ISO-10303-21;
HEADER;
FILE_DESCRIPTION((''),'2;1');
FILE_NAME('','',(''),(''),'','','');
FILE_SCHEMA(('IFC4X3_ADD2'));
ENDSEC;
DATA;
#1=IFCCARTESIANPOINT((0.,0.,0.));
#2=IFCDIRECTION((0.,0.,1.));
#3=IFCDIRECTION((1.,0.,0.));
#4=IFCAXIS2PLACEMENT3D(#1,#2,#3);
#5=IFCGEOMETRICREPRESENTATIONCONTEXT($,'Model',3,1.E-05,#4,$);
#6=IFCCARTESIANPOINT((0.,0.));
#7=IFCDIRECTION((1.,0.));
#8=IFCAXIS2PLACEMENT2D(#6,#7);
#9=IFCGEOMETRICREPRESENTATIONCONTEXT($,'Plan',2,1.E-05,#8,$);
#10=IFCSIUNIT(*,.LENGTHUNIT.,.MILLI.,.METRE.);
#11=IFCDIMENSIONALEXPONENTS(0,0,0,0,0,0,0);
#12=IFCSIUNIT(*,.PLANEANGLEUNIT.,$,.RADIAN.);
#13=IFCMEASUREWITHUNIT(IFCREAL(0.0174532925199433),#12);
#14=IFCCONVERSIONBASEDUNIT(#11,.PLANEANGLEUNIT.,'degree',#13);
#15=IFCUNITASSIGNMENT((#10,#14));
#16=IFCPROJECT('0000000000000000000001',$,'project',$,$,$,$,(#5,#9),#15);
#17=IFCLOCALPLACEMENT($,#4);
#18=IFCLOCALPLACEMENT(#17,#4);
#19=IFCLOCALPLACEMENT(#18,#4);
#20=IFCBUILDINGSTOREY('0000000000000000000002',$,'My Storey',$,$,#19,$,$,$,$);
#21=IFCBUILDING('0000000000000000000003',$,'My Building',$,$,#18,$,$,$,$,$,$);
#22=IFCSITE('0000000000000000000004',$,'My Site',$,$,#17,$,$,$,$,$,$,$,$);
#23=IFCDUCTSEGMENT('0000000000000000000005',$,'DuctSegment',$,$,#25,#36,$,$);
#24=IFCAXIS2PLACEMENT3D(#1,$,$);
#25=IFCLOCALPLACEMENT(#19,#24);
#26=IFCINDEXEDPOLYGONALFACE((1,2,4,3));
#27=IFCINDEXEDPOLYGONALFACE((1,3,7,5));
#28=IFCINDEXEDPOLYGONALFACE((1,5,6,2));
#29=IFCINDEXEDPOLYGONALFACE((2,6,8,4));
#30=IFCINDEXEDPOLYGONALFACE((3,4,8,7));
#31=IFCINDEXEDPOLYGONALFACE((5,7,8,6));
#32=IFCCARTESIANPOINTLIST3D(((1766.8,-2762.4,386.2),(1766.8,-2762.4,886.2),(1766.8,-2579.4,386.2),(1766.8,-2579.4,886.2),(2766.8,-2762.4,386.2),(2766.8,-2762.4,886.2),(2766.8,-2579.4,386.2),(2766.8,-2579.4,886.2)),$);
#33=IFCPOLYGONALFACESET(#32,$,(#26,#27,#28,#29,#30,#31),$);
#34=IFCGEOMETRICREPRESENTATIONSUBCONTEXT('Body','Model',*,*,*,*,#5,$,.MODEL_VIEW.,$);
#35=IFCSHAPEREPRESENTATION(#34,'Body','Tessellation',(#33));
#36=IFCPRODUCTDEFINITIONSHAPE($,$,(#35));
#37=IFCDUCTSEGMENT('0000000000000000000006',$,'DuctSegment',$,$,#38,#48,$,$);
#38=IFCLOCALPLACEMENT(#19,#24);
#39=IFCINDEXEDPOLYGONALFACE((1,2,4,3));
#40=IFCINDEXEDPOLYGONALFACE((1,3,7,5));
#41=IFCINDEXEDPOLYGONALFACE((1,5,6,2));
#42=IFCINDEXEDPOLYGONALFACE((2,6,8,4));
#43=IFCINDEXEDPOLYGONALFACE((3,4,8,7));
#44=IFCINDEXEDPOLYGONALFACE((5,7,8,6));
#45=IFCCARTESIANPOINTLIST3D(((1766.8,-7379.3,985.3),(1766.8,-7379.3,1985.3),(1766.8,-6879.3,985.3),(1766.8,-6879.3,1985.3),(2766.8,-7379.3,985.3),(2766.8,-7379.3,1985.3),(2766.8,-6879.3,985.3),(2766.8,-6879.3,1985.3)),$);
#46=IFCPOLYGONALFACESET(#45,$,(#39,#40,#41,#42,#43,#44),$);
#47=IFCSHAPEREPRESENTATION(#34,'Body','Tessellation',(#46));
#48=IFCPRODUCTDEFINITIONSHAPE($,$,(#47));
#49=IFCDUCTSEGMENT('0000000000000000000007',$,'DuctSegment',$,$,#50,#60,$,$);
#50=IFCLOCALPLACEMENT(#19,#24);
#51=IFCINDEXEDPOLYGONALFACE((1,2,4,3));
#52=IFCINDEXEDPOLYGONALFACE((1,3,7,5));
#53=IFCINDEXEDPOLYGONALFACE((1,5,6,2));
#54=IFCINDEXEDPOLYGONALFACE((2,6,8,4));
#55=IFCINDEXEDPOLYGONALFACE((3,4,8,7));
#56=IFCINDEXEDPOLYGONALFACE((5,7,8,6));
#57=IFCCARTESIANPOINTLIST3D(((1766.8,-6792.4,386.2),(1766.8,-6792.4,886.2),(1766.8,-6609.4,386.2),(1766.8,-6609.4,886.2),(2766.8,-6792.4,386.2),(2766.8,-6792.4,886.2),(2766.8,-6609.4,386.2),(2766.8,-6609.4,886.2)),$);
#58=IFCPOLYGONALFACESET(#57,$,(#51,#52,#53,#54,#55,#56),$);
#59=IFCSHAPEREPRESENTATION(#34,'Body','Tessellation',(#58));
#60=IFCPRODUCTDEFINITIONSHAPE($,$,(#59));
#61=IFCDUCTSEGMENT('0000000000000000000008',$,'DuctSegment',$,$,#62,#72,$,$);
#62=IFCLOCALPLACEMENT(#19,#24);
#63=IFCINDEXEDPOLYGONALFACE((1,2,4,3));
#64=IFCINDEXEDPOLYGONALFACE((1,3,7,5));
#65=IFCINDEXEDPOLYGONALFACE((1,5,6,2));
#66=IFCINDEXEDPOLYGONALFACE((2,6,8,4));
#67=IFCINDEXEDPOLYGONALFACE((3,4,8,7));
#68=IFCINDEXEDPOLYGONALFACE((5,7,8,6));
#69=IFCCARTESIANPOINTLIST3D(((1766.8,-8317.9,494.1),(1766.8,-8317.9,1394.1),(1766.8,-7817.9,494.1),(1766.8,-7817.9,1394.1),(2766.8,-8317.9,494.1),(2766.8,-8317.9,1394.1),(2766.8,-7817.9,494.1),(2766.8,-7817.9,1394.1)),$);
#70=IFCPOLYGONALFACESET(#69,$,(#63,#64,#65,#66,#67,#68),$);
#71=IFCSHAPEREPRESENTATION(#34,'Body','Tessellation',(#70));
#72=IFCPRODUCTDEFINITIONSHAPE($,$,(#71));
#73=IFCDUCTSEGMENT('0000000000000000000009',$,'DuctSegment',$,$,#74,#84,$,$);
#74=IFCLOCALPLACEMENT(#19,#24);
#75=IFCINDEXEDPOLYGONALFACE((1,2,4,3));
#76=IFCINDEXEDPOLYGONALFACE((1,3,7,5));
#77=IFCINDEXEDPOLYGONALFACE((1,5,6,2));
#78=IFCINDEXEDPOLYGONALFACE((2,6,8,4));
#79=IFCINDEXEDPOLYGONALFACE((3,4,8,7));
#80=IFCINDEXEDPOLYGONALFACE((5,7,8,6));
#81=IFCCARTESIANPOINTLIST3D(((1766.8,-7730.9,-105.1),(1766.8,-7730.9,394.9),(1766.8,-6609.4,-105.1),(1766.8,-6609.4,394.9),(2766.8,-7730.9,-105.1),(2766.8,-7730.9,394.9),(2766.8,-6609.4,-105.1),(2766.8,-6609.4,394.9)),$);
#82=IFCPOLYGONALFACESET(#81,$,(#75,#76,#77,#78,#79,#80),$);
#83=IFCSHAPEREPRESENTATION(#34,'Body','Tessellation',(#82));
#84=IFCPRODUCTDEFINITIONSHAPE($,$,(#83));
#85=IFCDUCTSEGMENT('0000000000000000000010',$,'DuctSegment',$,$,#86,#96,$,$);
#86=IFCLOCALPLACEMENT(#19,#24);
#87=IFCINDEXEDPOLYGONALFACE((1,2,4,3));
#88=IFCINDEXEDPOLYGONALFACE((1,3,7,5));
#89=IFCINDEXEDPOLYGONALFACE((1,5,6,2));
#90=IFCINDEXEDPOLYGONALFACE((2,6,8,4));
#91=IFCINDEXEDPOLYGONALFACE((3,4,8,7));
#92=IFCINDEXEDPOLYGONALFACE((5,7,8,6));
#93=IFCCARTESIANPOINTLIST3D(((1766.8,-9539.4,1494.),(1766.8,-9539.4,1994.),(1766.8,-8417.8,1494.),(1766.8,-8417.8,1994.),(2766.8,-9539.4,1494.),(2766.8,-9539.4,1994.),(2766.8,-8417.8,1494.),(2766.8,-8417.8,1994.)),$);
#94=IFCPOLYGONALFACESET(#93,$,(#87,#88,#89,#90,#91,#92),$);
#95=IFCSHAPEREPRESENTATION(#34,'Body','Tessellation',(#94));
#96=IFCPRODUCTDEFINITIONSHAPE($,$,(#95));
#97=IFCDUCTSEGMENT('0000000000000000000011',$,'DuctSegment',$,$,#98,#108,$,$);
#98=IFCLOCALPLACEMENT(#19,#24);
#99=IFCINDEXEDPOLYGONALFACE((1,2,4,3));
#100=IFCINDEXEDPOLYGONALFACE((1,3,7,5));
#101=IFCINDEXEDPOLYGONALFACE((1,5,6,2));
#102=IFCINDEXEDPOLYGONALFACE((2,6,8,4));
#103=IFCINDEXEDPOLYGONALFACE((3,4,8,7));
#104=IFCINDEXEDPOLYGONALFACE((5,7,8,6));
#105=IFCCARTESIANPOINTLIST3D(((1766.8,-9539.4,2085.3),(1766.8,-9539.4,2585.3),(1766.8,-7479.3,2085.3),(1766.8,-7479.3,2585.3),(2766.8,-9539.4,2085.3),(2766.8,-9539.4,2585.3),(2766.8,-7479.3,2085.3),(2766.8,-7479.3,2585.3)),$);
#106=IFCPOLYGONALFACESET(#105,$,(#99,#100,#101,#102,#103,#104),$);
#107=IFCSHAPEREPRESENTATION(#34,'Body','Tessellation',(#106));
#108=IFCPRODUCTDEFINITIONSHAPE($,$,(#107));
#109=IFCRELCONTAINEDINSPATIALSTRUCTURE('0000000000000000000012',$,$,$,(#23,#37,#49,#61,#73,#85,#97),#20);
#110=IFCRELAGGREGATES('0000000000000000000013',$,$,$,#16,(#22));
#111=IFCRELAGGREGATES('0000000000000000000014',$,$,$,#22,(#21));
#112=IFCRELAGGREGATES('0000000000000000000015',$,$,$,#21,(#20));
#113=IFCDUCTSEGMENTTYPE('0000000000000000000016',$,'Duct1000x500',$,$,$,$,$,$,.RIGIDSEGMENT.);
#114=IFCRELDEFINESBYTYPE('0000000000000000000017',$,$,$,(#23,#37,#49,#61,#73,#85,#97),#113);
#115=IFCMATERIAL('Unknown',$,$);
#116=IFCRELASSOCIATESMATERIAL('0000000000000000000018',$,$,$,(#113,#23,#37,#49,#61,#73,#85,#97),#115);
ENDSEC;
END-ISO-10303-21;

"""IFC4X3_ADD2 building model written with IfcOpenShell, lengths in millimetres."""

from ifc_helpers import new_model, entity, si_unit, converted_unit, frame, origin_with_axes, origin_2d_with_axis, place, context, subcontext, project, spatial, rectangle, extrude, material, material_profile, profile_set, profile_usage, type_object, element, save


model = new_model("IFC4X3_ADD2")

# Units and contexts
model_context = context("Model", 3, precision=1e-05, world=origin_with_axes())
plan_context = context("Plan", 2, precision=1e-05, world=origin_2d_with_axis())
body_context = subcontext(model_context, "Body", "Model", "MODEL_VIEW")
ifc_project = project(units=[si_unit("LENGTHUNIT", "METRE", prefix="MILLI"), converted_unit("PLANEANGLEUNIT", "degree", entity("IfcReal", 0.0174532925199433), si_unit("PLANEANGLEUNIT", "RADIAN"), dimensions=[0, 0, 0, 0, 0, 0, 0])], contexts=[model_context, plan_context])

# Site, building, storey
site_placement = place(None, origin_with_axes())
site = spatial("IfcSite", under=ifc_project, at=site_placement, Name="My Site")
building_placement = place(site_placement, origin_with_axes())
building = spatial("IfcBuilding", under=site, at=building_placement, Name="My Building")
storey_placement = place(building_placement, origin_with_axes())
storey = spatial("IfcBuildingStorey", under=building, at=storey_placement, Name="My Storey")

# Duct segments
ifc_material = material(Name="Unknown")
ifc_material_profile_1 = material_profile(ifc_material, rectangle(XDim=1000.0, YDim=500.0))
ifc_profile_set_1 = profile_set([ifc_material_profile_1], Name="duct1000x500")
duct_segment_type_1 = type_object("IfcDuctSegmentType", Name="Duct1000x500", PredefinedType="RIGIDSEGMENT", material=ifc_profile_set_1)
ifc_profile_usage_1 = profile_usage(ifc_profile_set_1, cardinal=5)
duct_segment_1_placement = place(storey_placement, frame((2266.8, -2762.4, 636.2), z_axis=(0.0, 1.0, 0.0), x_axis=(-1.0, 0.0, 0.0)))
element("IfcDuctSegment", 1, at=duct_segment_1_placement, inside=storey, type_object=duct_segment_type_1, material=ifc_profile_usage_1, Name="DuctSegment", context=body_context, shape_type="SweptSolid", body=[
    extrude(rectangle(XDim=1000.0, YDim=500.0), origin_with_axes(), (0.0, 0.0, 1.0), 183.0),
])
ifc_profile_usage_2 = profile_usage(ifc_profile_set_1, cardinal=5)
duct_segment_2_placement = place(storey_placement, frame((2266.8, -7129.3, 1985.3), z_axis=(0.0, 0.0, -1.0), x_axis=(1.0, 0.0, 0.0)))
element("IfcDuctSegment", 2, at=duct_segment_2_placement, inside=storey, type_object=duct_segment_type_1, material=ifc_profile_usage_2, Name="DuctSegment", context=body_context, shape_type="SweptSolid", body=[
    extrude(rectangle(XDim=1000.0, YDim=500.0), origin_with_axes(), (0.0, 0.0, 1.0), 1000.0),
])
ifc_profile_usage_3 = profile_usage(ifc_profile_set_1, cardinal=5)
duct_segment_3_placement = place(storey_placement, frame((2266.8, -6609.4, 636.2), z_axis=(0.0, -1.0, 0.0), x_axis=(1.0, 0.0, 0.0)))
element("IfcDuctSegment", 3, at=duct_segment_3_placement, inside=storey, type_object=duct_segment_type_1, material=ifc_profile_usage_3, Name="DuctSegment", context=body_context, shape_type="SweptSolid", body=[
    extrude(rectangle(XDim=1000.0, YDim=500.0), origin_with_axes(), (0.0, 0.0, 1.0), 183.0),
])
ifc_profile_usage_4 = profile_usage(ifc_profile_set_1, cardinal=5)
duct_segment_4_placement = place(storey_placement, frame((2266.8, -8067.9, 1394.1), z_axis=(0.0, 0.0, -1.0), x_axis=(1.0, 0.0, 0.0)))
element("IfcDuctSegment", 4, at=duct_segment_4_placement, inside=storey, type_object=duct_segment_type_1, material=ifc_profile_usage_4, Name="DuctSegment", context=body_context, shape_type="SweptSolid", body=[
    extrude(rectangle(XDim=1000.0, YDim=500.0), origin_with_axes(), (0.0, 0.0, 1.0), 900.0),
])
ifc_profile_usage_5 = profile_usage(ifc_profile_set_1, cardinal=5)
duct_segment_5_placement = place(storey_placement, frame((2266.8, -6609.4, 144.9), z_axis=(0.0, -1.0, 0.0), x_axis=(1.0, 0.0, 0.0)))
element("IfcDuctSegment", 5, at=duct_segment_5_placement, inside=storey, type_object=duct_segment_type_1, material=ifc_profile_usage_5, Name="DuctSegment", context=body_context, shape_type="SweptSolid", body=[
    extrude(rectangle(XDim=1000.0, YDim=500.0), origin_with_axes(), (0.0, 0.0, 1.0), 1121.5),
])
ifc_profile_usage_6 = profile_usage(ifc_profile_set_1, cardinal=5)
duct_segment_6_placement = place(storey_placement, frame((2266.8, -8417.8, 1744.0), z_axis=(0.0, -1.0, 0.0), x_axis=(1.0, 0.0, 0.0)))
element("IfcDuctSegment", 6, at=duct_segment_6_placement, inside=storey, type_object=duct_segment_type_1, material=ifc_profile_usage_6, Name="DuctSegment", context=body_context, shape_type="SweptSolid", body=[
    extrude(rectangle(XDim=1000.0, YDim=500.0), origin_with_axes(), (0.0, 0.0, 1.0), 1121.5),
])
ifc_profile_usage_7 = profile_usage(ifc_profile_set_1, cardinal=5)
duct_segment_7_placement = place(storey_placement, frame((2266.8, -7479.3, 2335.3), z_axis=(0.0, -1.0, 0.0), x_axis=(1.0, 0.0, 0.0)))
element("IfcDuctSegment", 7, at=duct_segment_7_placement, inside=storey, type_object=duct_segment_type_1, material=ifc_profile_usage_7, Name="DuctSegment", context=body_context, shape_type="SweptSolid", body=[
    extrude(rectangle(XDim=1000.0, YDim=500.0), origin_with_axes(), (0.0, 0.0, 1.0), 2060.1),
])

save(model, "model.ifc")
